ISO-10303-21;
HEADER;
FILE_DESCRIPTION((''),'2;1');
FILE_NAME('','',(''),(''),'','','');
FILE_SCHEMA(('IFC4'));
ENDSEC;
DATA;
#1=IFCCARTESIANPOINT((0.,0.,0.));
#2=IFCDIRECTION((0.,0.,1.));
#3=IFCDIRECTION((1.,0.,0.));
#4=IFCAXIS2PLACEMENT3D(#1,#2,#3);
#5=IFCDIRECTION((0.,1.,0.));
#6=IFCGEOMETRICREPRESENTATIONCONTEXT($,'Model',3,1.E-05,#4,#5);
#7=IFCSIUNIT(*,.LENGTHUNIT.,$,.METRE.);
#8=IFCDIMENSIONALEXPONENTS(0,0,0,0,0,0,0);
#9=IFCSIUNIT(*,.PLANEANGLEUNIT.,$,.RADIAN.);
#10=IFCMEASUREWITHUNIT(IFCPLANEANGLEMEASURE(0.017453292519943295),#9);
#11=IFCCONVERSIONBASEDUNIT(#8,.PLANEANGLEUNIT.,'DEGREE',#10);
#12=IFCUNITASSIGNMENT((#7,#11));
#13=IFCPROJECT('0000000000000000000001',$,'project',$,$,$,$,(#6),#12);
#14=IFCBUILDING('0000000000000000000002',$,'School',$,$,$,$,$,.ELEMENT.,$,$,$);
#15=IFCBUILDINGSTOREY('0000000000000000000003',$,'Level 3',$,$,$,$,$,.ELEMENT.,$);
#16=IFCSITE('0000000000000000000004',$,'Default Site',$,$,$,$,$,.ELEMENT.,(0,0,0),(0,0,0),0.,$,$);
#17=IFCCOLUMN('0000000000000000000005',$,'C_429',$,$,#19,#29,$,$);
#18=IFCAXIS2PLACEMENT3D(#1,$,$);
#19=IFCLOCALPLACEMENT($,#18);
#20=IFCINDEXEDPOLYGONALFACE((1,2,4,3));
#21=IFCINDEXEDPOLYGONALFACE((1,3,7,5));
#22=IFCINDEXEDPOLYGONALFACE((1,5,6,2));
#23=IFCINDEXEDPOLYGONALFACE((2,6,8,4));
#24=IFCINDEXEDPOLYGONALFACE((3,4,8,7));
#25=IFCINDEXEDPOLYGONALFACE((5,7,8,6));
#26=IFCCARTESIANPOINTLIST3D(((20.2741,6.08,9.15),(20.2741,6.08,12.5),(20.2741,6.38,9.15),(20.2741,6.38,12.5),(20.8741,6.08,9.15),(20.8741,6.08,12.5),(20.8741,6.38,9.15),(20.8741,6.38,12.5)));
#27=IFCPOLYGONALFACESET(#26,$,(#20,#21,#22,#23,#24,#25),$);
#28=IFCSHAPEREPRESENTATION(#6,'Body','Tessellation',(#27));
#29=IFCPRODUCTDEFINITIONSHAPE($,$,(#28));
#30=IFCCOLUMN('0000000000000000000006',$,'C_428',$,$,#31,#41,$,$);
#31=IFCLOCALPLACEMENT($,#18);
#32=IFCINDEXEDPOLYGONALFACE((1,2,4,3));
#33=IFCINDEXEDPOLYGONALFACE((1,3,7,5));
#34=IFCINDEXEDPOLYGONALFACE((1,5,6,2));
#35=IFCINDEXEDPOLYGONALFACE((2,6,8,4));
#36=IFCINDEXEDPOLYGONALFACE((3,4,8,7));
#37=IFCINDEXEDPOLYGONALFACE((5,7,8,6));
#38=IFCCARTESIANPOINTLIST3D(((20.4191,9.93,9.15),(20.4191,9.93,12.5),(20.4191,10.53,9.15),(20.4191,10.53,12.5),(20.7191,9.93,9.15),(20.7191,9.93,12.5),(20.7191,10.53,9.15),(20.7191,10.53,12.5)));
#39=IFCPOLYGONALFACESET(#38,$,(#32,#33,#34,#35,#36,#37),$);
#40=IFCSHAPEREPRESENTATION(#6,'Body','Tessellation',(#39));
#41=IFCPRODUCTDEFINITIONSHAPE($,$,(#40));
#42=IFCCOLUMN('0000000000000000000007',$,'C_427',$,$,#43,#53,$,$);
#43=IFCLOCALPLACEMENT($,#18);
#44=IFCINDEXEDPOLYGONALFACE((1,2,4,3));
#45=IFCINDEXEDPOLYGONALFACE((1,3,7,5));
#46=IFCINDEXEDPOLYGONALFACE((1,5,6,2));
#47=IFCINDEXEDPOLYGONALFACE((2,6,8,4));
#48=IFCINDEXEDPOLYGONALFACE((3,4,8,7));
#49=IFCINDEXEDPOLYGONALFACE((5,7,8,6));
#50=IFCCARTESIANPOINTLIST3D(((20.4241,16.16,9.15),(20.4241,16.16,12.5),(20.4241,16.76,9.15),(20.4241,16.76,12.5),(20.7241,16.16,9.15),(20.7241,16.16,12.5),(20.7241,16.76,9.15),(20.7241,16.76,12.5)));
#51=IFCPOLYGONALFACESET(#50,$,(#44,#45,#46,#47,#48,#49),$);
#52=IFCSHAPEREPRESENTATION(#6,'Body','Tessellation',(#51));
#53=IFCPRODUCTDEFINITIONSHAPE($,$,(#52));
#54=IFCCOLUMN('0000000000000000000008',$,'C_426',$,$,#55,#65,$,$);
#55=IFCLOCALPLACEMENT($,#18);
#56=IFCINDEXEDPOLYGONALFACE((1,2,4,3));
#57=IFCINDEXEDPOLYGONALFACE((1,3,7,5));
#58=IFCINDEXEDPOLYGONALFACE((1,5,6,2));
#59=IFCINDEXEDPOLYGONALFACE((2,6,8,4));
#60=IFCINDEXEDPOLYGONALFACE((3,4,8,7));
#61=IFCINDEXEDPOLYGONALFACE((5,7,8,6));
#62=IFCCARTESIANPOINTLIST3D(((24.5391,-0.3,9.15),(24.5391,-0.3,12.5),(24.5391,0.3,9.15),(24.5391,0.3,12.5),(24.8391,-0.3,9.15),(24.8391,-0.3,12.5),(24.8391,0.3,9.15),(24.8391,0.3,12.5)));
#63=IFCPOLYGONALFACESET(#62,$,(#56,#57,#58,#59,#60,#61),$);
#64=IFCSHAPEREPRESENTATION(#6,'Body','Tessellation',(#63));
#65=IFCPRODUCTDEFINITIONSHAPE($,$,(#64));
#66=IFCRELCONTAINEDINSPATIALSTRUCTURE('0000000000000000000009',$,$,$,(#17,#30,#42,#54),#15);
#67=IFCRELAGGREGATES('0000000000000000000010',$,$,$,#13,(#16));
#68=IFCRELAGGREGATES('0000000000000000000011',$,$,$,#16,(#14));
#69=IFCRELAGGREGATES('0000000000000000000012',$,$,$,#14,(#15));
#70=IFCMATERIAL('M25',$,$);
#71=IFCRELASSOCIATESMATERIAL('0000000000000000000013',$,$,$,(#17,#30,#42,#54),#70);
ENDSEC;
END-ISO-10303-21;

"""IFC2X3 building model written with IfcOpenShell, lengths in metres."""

from ifc_helpers import new_model, entity, si_unit, converted_unit, direction, frame, frame_2d, origin_with_axes, place, context, project, spatial, rectangle, extrude, material, element, save


model = new_model("IFC2X3")

# Units and contexts
model_context = context("Model", 3, precision=1e-05, world=origin_with_axes(), true_north=direction((0.0, 1.0, 0.0)))
ifc_project = project(units=[si_unit("LENGTHUNIT", "METRE"), converted_unit("PLANEANGLEUNIT", "DEGREE", entity("IfcPlaneAngleMeasure", 0.017453292519943295), si_unit("PLANEANGLEUNIT", "RADIAN"), dimensions=[0, 0, 0, 0, 0, 0, 0])], contexts=[model_context])

# Site, building, storey
site = spatial("IfcSite", under=ifc_project, Name="Default Site", CompositionType="ELEMENT", RefLatitude=(0, 0, 0), RefLongitude=(0, 0, 0), RefElevation=0.0)
building = spatial("IfcBuilding", under=site, Name="School", CompositionType="ELEMENT")
storey = spatial("IfcBuildingStorey", under=building, Name="Level 3", CompositionType="ELEMENT")

# Columns
ifc_material = material(Name="M25")
placement = place(None, origin_with_axes())
element("IfcColumn", 1, at=placement, inside=storey, material=ifc_material, Name="C_429", context=model_context, shape_type="SweptSolid", body=[
    extrude(rectangle(XDim=0.6, YDim=0.3, at=frame_2d((0.0, 0.0), x_axis=(1.0, 0.0, 0.0))), frame((20.5741, 6.23, 9.15), z_axis=(0.0, 0.0, 1.0), x_axis=(1.0, 0.0, 0.0)), (0.0, 0.0, 1.0), 3.35),
])
element("IfcColumn", 2, at=placement, inside=storey, material=ifc_material, Name="C_428", context=model_context, shape_type="SweptSolid", body=[
    extrude(rectangle(XDim=0.3, YDim=0.6, at=frame_2d((0.0, 0.0), x_axis=(1.0, 0.0, 0.0))), frame((20.5691, 10.23, 9.15), z_axis=(0.0, 0.0, 1.0), x_axis=(1.0, 0.0, 0.0)), (0.0, 0.0, 1.0), 3.35),
])
element("IfcColumn", 3, at=placement, inside=storey, material=ifc_material, Name="C_427", context=model_context, shape_type="SweptSolid", body=[
    extrude(rectangle(XDim=0.3, YDim=0.6, at=frame_2d((0.0, 0.0), x_axis=(1.0, 0.0, 0.0))), frame((20.5741, 16.46, 9.15), z_axis=(0.0, 0.0, 1.0), x_axis=(1.0, 0.0, 0.0)), (0.0, 0.0, 1.0), 3.35),
])
element("IfcColumn", 4, at=placement, inside=storey, material=ifc_material, Name="C_426", context=model_context, shape_type="SweptSolid", body=[
    extrude(rectangle(XDim=0.3, YDim=0.6, at=frame_2d((0.0, 0.0), x_axis=(1.0, 0.0, 0.0))), frame((24.6891, 0.0, 9.15), z_axis=(0.0, 0.0, 1.0), x_axis=(1.0, 0.0, 0.0)), (0.0, 0.0, 1.0), 3.35),
])

save(model, "model.ifc")
